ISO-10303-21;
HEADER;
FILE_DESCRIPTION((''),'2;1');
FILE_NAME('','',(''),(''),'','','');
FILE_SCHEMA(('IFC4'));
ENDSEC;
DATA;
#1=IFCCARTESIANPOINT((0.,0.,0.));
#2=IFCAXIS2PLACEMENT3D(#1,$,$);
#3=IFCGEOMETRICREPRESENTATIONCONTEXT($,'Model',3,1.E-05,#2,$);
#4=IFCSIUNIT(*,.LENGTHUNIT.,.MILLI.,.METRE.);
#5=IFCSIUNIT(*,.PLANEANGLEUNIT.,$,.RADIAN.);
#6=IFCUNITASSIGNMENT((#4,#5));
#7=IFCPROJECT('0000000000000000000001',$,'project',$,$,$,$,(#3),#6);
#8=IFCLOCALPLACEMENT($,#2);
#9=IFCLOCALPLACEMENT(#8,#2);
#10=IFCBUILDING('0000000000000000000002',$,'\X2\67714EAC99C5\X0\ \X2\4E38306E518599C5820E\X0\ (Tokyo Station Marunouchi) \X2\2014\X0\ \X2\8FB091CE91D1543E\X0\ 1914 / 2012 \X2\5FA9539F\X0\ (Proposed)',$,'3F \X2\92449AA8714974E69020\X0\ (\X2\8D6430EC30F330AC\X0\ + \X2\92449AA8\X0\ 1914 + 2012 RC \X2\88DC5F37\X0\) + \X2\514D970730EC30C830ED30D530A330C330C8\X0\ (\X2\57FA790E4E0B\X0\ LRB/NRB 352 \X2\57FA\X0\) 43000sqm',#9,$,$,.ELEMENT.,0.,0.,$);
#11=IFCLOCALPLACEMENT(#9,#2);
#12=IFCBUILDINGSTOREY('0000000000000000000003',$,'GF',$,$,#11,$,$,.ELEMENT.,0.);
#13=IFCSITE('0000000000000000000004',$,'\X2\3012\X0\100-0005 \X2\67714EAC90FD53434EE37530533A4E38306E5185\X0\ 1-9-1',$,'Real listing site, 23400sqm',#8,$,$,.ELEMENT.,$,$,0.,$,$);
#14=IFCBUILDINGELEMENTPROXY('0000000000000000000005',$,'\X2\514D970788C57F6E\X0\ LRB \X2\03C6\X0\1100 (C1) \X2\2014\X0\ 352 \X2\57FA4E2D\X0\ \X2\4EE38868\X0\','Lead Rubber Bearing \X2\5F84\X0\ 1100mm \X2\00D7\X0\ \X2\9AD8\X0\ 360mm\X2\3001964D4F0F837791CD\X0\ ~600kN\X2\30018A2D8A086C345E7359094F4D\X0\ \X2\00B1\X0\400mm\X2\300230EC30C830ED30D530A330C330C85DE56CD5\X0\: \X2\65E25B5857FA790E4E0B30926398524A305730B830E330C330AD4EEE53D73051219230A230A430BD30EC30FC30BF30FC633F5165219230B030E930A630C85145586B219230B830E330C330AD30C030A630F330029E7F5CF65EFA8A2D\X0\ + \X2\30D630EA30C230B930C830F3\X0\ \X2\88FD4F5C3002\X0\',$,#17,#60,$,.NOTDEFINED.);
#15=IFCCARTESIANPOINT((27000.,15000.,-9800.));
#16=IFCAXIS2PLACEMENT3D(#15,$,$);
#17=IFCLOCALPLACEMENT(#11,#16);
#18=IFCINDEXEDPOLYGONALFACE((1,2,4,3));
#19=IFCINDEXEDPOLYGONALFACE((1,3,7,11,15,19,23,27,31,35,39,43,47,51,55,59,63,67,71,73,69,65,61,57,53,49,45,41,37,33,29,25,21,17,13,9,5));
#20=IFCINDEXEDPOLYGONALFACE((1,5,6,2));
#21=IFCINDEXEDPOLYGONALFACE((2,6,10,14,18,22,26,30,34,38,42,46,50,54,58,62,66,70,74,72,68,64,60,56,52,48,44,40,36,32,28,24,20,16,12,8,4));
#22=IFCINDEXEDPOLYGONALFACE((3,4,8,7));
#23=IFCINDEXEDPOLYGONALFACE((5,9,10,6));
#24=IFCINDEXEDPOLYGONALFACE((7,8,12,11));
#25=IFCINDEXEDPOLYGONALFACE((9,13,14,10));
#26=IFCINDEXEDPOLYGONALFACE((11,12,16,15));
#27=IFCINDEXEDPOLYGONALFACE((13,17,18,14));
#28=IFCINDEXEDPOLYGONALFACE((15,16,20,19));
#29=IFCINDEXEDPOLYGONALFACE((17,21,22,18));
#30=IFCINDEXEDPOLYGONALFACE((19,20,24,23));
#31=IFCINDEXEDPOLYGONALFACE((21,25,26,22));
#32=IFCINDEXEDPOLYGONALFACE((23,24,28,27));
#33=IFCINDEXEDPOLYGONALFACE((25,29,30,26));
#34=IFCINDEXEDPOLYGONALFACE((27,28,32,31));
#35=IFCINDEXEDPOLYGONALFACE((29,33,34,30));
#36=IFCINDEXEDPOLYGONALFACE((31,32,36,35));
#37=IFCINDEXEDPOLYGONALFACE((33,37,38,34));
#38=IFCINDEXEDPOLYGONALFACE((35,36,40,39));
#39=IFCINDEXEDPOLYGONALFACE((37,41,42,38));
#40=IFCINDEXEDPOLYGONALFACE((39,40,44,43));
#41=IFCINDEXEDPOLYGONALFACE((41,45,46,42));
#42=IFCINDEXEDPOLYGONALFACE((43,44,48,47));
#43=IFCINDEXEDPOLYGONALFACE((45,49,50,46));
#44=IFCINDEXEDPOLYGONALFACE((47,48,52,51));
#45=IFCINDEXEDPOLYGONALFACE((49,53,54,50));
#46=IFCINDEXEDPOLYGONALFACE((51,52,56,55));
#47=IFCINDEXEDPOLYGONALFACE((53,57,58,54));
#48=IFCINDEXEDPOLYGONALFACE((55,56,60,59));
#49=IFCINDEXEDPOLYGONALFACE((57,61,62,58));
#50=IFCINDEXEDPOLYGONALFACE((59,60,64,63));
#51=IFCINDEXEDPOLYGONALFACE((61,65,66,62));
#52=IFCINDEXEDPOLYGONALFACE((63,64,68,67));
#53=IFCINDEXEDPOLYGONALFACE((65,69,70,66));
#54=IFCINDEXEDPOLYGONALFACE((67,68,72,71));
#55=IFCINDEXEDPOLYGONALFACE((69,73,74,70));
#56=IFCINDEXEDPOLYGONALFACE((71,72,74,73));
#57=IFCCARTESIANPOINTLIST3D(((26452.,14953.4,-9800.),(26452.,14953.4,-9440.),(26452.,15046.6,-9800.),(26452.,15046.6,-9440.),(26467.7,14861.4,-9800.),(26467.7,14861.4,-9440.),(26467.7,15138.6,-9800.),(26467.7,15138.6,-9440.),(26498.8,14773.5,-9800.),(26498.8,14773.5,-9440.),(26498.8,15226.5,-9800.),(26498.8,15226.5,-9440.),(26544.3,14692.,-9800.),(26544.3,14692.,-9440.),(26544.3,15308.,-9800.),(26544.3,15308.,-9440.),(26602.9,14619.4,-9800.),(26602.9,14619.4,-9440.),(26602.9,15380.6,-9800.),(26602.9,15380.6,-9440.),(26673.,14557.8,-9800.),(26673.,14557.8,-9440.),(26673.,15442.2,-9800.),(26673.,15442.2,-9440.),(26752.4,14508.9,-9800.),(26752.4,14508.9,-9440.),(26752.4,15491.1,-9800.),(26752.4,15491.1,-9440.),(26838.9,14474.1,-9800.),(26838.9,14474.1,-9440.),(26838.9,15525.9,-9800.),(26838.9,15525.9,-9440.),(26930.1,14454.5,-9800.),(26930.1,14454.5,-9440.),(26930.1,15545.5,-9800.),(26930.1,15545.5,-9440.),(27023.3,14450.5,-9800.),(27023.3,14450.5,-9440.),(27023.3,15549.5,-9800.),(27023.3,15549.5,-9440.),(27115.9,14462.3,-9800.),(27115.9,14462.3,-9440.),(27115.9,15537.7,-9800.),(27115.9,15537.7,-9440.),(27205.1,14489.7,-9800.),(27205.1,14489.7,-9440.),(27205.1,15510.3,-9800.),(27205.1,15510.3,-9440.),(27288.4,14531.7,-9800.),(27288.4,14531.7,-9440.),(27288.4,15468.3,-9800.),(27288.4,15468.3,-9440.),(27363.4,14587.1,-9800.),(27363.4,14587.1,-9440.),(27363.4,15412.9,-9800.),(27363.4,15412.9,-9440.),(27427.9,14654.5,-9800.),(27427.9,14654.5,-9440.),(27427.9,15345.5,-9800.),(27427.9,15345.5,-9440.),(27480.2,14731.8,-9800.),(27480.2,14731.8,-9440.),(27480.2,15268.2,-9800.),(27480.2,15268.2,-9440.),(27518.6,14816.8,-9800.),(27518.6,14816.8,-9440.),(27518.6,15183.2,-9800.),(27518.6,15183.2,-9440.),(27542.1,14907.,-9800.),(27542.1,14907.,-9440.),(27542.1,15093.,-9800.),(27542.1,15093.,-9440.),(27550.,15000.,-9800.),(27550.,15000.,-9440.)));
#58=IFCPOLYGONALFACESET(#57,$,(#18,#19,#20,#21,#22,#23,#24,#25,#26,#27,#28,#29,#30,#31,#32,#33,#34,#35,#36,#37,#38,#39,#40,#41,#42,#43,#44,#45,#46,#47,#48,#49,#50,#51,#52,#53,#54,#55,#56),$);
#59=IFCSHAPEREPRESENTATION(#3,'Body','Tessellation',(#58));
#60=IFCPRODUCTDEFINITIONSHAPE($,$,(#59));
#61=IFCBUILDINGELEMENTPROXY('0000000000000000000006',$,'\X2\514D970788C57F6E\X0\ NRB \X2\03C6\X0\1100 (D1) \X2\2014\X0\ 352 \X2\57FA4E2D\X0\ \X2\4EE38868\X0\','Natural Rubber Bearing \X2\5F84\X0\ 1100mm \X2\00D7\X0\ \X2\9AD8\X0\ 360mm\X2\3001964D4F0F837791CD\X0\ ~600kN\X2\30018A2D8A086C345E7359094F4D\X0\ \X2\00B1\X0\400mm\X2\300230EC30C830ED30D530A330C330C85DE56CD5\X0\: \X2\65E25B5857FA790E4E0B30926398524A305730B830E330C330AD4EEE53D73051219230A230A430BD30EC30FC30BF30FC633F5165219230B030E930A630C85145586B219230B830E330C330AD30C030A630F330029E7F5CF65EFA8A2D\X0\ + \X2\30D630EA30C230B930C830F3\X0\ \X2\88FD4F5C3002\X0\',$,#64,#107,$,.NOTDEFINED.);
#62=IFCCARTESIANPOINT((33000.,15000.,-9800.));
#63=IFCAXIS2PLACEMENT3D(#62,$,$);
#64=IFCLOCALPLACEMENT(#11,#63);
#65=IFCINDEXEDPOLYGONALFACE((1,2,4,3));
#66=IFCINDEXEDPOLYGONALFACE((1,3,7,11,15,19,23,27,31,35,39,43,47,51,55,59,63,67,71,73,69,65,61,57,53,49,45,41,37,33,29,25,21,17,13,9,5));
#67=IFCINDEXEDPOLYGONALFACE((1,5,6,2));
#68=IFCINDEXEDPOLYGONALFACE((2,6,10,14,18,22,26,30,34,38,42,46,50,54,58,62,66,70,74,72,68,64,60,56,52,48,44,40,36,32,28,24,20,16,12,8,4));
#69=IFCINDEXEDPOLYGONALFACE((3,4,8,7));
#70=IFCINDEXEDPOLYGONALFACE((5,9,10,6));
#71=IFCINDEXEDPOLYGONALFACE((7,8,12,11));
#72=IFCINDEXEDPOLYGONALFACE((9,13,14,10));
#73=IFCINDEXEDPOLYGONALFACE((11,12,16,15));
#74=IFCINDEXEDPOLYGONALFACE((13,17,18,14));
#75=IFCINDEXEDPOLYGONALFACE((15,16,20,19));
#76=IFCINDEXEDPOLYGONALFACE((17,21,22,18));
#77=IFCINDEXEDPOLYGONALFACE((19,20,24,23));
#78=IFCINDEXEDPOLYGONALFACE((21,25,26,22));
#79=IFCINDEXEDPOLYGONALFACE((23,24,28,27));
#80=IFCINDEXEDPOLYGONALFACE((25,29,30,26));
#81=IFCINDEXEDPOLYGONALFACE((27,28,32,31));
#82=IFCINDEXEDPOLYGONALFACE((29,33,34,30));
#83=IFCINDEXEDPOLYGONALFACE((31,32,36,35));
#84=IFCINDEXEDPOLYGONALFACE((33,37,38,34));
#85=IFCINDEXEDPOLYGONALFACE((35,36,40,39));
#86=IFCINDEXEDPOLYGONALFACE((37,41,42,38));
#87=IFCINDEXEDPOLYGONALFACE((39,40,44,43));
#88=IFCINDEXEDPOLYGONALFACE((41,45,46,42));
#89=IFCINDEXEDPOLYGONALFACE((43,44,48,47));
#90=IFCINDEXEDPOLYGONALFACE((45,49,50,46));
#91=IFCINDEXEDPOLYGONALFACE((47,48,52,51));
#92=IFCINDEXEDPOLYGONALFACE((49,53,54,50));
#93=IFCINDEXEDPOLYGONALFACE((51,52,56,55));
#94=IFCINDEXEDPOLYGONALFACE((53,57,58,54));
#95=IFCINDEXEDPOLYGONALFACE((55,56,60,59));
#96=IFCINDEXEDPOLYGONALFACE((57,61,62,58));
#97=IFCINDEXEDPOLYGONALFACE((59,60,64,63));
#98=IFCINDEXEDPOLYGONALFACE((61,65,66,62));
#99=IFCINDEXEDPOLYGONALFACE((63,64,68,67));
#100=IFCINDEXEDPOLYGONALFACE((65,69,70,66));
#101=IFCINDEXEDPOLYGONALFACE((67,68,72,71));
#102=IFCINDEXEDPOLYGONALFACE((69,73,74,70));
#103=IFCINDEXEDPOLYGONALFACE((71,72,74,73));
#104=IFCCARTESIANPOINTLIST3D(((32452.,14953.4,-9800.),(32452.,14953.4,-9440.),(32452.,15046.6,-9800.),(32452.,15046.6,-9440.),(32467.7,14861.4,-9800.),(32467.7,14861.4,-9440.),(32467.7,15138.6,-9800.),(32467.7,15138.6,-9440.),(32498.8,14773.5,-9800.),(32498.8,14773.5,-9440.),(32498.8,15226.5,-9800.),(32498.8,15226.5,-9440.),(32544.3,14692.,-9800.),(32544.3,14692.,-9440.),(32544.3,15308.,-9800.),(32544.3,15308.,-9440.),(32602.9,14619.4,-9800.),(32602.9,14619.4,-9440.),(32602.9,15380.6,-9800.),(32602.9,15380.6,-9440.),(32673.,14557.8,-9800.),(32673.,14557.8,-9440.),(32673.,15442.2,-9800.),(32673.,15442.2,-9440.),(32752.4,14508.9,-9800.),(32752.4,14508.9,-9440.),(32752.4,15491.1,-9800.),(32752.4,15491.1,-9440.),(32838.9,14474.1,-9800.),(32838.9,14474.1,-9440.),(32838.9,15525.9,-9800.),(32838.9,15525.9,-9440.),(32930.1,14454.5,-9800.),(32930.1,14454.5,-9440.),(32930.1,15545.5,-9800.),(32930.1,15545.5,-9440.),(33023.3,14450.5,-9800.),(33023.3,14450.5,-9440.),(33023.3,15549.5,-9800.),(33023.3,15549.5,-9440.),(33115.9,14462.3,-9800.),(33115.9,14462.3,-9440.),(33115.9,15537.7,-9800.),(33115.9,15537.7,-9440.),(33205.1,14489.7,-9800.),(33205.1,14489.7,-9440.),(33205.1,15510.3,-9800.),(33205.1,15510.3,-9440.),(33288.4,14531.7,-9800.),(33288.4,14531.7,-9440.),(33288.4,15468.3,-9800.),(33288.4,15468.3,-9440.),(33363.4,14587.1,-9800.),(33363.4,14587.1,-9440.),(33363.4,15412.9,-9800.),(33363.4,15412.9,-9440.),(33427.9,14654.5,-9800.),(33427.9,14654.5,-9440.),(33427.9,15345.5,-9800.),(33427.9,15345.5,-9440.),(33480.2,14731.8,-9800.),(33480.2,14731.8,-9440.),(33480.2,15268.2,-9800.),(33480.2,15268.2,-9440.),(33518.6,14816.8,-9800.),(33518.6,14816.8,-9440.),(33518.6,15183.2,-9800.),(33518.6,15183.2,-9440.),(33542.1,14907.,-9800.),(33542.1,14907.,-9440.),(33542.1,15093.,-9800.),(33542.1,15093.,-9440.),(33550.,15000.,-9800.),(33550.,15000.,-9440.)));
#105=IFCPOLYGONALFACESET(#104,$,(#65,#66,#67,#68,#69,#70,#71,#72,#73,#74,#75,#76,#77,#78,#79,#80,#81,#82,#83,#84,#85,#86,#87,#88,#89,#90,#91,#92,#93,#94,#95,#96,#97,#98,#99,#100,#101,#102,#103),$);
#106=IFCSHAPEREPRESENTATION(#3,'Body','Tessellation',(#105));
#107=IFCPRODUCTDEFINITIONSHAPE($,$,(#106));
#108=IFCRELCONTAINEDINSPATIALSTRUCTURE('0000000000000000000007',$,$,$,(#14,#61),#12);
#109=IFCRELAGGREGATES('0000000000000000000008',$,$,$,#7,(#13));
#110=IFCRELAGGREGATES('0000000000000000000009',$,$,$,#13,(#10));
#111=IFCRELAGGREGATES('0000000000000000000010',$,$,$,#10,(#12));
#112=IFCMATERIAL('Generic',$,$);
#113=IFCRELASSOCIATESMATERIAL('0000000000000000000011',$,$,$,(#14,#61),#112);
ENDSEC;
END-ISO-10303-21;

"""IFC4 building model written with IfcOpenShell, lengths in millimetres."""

from ifc_helpers import new_model, si_unit, frame, origin, origin_2d, place, context, project, spatial, circle, extrude, material, element, save


model = new_model("IFC4")

# Units and contexts
model_context = context("Model", 3, precision=1e-05, world=origin())
ifc_project = project(units=[si_unit("LENGTHUNIT", "METRE", prefix="MILLI"), si_unit("PLANEANGLEUNIT", "RADIAN")], contexts=[model_context])

# Site, building, storey
site_placement = place(None, origin())
site = spatial("IfcSite", under=ifc_project, at=site_placement, Name="〒100-0005 東京都千代田区丸の内 1-9-1", ObjectType="Real listing site, 23400sqm", CompositionType="ELEMENT", RefElevation=0.0)
building_placement = place(site_placement, origin())
building = spatial("IfcBuilding", under=site, at=building_placement, Name="東京駅 丸の内駅舎 (Tokyo Station Marunouchi) — 辰野金吾 1914 / 2012 復原 (Proposed)", ObjectType="3F 鉄骨煉瓦造 (赤レンガ + 鉄骨 1914 + 2012 RC 補強) + 免震レトロフィット (基礎下 LRB/NRB 352 基) 43000sqm", CompositionType="ELEMENT", ElevationOfRefHeight=0.0, ElevationOfTerrain=0.0)
storey_placement = place(building_placement, origin())
storey = spatial("IfcBuildingStorey", under=building, at=storey_placement, Name="GF", CompositionType="ELEMENT", Elevation=0.0)

# Shared definitions
ifc_material_1 = material(Name="Generic")

# Building element proxies
proxy_1_placement = place(storey_placement, frame((27000.0, 15000.0, -9800.0)))
element("IfcBuildingElementProxy", 1, at=proxy_1_placement, inside=storey, material=ifc_material_1, Name="免震装置 LRB φ1100 (C1) — 352 基中 代表", Description="Lead Rubber Bearing 径 1100mm × 高 360mm、降伏荷重 ~600kN、設計水平変位 ±400mm。レトロフィット工法: 既存基礎下を掘削しジャッキ仮受け→アイソレーター挿入→グラウト充填→ジャッキダウン。鹿島建設 + ブリヂストン 製作。", PredefinedType="NOTDEFINED", context=model_context, shape_type="SweptSolid", body=[
    extrude(circle(Radius=550.0, at=origin_2d()), frame((27000.0, 15000.0, -9800.0)), (0.0, 0.0, 1.0), 360.0),
])
proxy_2_placement = place(storey_placement, frame((33000.0, 15000.0, -9800.0)))
element("IfcBuildingElementProxy", 2, at=proxy_2_placement, inside=storey, material=ifc_material_1, Name="免震装置 NRB φ1100 (D1) — 352 基中 代表", Description="Natural Rubber Bearing 径 1100mm × 高 360mm、降伏荷重 ~600kN、設計水平変位 ±400mm。レトロフィット工法: 既存基礎下を掘削しジャッキ仮受け→アイソレーター挿入→グラウト充填→ジャッキダウン。鹿島建設 + ブリヂストン 製作。", PredefinedType="NOTDEFINED", context=model_context, shape_type="SweptSolid", body=[
    extrude(circle(Radius=550.0, at=origin_2d()), frame((33000.0, 15000.0, -9800.0)), (0.0, 0.0, 1.0), 360.0),
])

save(model, "model.ifc")
